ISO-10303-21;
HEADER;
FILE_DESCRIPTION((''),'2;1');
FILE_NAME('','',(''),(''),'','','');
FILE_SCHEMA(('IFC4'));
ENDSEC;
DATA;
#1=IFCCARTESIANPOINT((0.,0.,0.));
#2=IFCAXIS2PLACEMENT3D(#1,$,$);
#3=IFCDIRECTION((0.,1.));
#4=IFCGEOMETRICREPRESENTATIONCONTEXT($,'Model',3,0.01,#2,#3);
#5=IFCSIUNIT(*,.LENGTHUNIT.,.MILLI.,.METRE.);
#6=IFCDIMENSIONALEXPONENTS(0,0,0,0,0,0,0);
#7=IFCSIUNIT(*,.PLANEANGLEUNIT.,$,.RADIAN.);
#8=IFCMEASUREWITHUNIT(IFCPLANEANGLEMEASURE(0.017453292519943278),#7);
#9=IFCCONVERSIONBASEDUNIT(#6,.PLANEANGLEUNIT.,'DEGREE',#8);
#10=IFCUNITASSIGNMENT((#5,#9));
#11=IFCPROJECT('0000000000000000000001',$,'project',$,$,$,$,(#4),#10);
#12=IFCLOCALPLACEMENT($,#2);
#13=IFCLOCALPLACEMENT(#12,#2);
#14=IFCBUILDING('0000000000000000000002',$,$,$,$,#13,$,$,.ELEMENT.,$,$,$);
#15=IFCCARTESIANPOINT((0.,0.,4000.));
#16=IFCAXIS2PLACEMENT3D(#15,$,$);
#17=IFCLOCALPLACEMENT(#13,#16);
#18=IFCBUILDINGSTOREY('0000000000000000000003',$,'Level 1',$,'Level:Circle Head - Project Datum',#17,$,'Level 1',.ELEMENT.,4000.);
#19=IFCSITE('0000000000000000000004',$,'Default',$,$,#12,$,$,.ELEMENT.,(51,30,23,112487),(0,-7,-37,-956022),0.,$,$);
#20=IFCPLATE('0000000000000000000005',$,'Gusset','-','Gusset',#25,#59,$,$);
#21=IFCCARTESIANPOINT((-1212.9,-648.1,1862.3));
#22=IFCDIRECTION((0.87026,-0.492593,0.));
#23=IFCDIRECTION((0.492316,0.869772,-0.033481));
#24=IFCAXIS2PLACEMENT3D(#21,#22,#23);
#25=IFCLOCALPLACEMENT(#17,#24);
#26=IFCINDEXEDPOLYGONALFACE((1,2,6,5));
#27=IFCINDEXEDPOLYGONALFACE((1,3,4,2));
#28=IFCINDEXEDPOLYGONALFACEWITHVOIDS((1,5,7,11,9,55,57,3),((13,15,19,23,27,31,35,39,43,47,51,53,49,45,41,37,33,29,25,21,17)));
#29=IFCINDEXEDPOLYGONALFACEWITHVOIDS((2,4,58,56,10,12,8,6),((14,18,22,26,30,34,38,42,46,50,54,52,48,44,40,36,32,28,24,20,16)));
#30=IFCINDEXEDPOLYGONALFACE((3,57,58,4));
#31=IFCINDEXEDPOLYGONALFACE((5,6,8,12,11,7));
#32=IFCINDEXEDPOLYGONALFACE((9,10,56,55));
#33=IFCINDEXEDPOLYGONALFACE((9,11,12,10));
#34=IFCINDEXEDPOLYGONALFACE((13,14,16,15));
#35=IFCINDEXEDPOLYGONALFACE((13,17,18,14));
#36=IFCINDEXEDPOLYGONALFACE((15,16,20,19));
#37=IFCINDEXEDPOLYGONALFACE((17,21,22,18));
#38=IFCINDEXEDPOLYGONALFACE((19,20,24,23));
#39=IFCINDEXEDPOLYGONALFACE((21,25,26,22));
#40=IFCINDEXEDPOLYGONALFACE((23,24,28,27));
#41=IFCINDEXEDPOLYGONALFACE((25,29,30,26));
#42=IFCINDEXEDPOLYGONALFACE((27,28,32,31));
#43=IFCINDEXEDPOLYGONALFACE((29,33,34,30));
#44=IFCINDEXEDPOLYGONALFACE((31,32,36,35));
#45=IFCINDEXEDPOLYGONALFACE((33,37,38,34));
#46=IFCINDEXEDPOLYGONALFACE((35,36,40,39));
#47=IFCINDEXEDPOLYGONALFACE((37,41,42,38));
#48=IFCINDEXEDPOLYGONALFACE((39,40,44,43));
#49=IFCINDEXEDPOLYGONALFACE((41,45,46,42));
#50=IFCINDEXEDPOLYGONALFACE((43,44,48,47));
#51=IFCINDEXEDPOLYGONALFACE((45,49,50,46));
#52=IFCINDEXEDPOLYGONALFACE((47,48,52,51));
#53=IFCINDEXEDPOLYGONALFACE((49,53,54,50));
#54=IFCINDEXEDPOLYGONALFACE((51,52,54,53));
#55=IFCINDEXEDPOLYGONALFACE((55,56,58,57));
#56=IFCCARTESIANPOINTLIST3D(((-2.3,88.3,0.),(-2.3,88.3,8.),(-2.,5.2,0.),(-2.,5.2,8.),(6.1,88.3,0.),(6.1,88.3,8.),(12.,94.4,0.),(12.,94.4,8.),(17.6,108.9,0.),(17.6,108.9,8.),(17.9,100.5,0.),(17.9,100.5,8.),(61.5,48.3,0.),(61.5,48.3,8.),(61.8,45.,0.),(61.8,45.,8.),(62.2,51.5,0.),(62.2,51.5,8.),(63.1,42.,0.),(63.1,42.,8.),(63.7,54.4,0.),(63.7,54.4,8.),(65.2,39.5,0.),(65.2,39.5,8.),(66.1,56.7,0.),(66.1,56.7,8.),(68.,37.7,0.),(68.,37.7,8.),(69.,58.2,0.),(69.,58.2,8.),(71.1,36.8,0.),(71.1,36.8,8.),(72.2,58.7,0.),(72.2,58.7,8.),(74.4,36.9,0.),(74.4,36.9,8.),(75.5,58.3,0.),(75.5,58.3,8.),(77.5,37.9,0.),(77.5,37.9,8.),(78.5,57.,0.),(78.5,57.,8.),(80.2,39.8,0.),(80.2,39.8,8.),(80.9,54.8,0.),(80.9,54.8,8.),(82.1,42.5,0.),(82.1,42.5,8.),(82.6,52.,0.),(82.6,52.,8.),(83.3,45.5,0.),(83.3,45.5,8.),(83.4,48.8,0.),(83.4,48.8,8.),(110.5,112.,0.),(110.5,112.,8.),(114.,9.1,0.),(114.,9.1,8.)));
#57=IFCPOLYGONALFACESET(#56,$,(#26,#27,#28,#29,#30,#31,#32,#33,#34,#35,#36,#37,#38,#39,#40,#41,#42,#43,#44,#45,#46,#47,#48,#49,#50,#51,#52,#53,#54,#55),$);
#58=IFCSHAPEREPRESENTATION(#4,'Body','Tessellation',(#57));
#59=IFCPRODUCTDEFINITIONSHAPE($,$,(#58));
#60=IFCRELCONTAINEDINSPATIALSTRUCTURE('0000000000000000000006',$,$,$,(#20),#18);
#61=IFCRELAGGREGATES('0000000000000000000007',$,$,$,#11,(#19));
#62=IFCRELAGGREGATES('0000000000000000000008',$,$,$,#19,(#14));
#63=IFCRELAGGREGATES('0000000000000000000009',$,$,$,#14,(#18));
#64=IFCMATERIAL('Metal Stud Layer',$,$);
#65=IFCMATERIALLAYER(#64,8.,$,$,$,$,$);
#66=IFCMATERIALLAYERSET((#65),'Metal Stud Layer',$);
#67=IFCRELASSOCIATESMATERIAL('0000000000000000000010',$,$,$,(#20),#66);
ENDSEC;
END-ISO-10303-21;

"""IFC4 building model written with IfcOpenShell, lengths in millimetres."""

from ifc_helpers import new_model, entity, si_unit, converted_unit, point, direction, frame, frame_2d, origin, origin_with_axes, origin_2d_with_axis, place, context, project, spatial, polyline, circle_curve, line_curve, trimmed, segment, composite_curve, circle, outline, extrude, material, layer, layer_set, element, save


model = new_model("IFC4")

# Units and contexts
model_context = context("Model", 3, precision=0.01, world=origin(), true_north=direction((0.0, 1.0)))
ifc_project = project(units=[si_unit("LENGTHUNIT", "METRE", prefix="MILLI"), converted_unit("PLANEANGLEUNIT", "DEGREE", entity("IfcPlaneAngleMeasure", 0.017453292519943278), si_unit("PLANEANGLEUNIT", "RADIAN"), dimensions=[0, 0, 0, 0, 0, 0, 0])], contexts=[model_context])

# Site, building, storey
site_placement = place(None, origin())
site = spatial("IfcSite", under=ifc_project, at=site_placement, Name="Default", CompositionType="ELEMENT", RefLatitude=(51, 30, 23, 112487), RefLongitude=(0, -7, -37, -956022), RefElevation=0.0)
building_placement = place(site_placement, origin())
building = spatial("IfcBuilding", under=site, at=building_placement, CompositionType="ELEMENT")
storey_placement = place(building_placement, frame((0.0, 0.0, 4000.0)))
storey = spatial("IfcBuildingStorey", under=building, at=storey_placement, Name="Level 1", ObjectType="Level:Circle Head - Project Datum", LongName="Level 1", CompositionType="ELEMENT", Elevation=4000.0)

# Plate, openings
ifc_material_1 = material(Name="Metal Stud Layer")
ifc_layer_1 = layer(ifc_material_1, 8.0)
ifc_layer_set_1 = layer_set([ifc_layer_1], Name="Metal Stud Layer")
plate_1_placement = place(storey_placement, frame((-1212.9, -648.1, 1862.3), z_axis=(0.87026, -0.492593, 0.0), x_axis=(0.492316, 0.869772, -0.033481)))
plate_1 = element("IfcPlate", 1, at=plate_1_placement, inside=storey, material=ifc_layer_set_1, Name="Gusset", Description="-", ObjectType="Gusset", context=model_context, shape_type="SweptSolid", body=[
    extrude(outline(polyline([(114.0, 9.1), (110.5, 112.0), (17.6, 108.9), (17.9, 100.5), (6.1, 88.3), (-2.3, 88.3), (-2.0, 5.2), (114.0, 9.1)])), origin_with_axes(), (0.0, 0.0, 1.0), 8.0),
])
opening_1_placement = place(plate_1_placement, origin_with_axes())
element("IfcOpeningElement", 2, at=opening_1_placement, cuts=plate_1, ObjectType="Opening", context=model_context, shape_type="SweptSolid", body=[
    extrude(outline(composite_curve([segment(trimmed(line_curve((17.9, 100.5), (-0.693597, -0.720363), 8.455359), [point((17.9, 100.5))], [point((12.0, 94.4))], True, "CARTESIAN"), True, "CONTINUOUS"), segment(trimmed(circle_curve(frame_2d((-2.4, 108.3), x_axis=(1.0, 0.0)), 20.0), [point((12.0, 94.4))], [point((17.6, 108.9))], True, "CARTESIAN"), True, "CONTINUOUS"), segment(trimmed(line_curve((17.6, 108.9), (0.033481, -0.999439), 8.455359), [point((17.6, 108.9))], [point((17.9, 100.5))], True, "CARTESIAN"), True, "CONTINUOUS")], self_intersect="UNKNOWN")), origin(), (0.0, 0.0, 1.0), 8.0),
])
opening_2_placement = place(plate_1_placement, origin_with_axes())
element("IfcOpeningElement", 3, at=opening_2_placement, cuts=plate_1, ObjectType="Opening", context=model_context, shape_type="SweptSolid", body=[
    extrude(outline(composite_curve([segment(trimmed(line_curve((6.1, 88.3), (-0.99999, -0.004369), 8.455359), [point((6.1, 88.3))], [point((-2.3, 88.3))], True, "CARTESIAN"), True, "CONTINUOUS"), segment(trimmed(circle_curve(frame_2d((-2.4, 108.3), x_axis=(1.0, 0.0)), 20.0), [point((-2.3, 88.3))], [point((12.0, 94.4))], True, "CARTESIAN"), True, "CONTINUOUS"), segment(trimmed(line_curve((12.0, 94.4), (-0.693597, -0.720363), 8.455359), [point((12.0, 94.4))], [point((6.1, 88.3))], True, "CARTESIAN"), True, "CONTINUOUS")], self_intersect="UNKNOWN")), origin(), (0.0, 0.0, 1.0), 8.0),
])
opening_3_placement = place(plate_1_placement, frame((72.5, 47.7, -0.5), z_axis=(0.0, 0.0, 1.0), x_axis=(0.877396, -0.479766, 0.0)))
element("IfcOpeningElement", 4, at=opening_3_placement, cuts=plate_1, ObjectType="Opening", context=model_context, shape_type="SweptSolid", body=[
    extrude(circle(Radius=11.0, at=origin_2d_with_axis()), origin(), (0.0, 0.0, 1.0), 9.0),
])

save(model, "model.ifc")
